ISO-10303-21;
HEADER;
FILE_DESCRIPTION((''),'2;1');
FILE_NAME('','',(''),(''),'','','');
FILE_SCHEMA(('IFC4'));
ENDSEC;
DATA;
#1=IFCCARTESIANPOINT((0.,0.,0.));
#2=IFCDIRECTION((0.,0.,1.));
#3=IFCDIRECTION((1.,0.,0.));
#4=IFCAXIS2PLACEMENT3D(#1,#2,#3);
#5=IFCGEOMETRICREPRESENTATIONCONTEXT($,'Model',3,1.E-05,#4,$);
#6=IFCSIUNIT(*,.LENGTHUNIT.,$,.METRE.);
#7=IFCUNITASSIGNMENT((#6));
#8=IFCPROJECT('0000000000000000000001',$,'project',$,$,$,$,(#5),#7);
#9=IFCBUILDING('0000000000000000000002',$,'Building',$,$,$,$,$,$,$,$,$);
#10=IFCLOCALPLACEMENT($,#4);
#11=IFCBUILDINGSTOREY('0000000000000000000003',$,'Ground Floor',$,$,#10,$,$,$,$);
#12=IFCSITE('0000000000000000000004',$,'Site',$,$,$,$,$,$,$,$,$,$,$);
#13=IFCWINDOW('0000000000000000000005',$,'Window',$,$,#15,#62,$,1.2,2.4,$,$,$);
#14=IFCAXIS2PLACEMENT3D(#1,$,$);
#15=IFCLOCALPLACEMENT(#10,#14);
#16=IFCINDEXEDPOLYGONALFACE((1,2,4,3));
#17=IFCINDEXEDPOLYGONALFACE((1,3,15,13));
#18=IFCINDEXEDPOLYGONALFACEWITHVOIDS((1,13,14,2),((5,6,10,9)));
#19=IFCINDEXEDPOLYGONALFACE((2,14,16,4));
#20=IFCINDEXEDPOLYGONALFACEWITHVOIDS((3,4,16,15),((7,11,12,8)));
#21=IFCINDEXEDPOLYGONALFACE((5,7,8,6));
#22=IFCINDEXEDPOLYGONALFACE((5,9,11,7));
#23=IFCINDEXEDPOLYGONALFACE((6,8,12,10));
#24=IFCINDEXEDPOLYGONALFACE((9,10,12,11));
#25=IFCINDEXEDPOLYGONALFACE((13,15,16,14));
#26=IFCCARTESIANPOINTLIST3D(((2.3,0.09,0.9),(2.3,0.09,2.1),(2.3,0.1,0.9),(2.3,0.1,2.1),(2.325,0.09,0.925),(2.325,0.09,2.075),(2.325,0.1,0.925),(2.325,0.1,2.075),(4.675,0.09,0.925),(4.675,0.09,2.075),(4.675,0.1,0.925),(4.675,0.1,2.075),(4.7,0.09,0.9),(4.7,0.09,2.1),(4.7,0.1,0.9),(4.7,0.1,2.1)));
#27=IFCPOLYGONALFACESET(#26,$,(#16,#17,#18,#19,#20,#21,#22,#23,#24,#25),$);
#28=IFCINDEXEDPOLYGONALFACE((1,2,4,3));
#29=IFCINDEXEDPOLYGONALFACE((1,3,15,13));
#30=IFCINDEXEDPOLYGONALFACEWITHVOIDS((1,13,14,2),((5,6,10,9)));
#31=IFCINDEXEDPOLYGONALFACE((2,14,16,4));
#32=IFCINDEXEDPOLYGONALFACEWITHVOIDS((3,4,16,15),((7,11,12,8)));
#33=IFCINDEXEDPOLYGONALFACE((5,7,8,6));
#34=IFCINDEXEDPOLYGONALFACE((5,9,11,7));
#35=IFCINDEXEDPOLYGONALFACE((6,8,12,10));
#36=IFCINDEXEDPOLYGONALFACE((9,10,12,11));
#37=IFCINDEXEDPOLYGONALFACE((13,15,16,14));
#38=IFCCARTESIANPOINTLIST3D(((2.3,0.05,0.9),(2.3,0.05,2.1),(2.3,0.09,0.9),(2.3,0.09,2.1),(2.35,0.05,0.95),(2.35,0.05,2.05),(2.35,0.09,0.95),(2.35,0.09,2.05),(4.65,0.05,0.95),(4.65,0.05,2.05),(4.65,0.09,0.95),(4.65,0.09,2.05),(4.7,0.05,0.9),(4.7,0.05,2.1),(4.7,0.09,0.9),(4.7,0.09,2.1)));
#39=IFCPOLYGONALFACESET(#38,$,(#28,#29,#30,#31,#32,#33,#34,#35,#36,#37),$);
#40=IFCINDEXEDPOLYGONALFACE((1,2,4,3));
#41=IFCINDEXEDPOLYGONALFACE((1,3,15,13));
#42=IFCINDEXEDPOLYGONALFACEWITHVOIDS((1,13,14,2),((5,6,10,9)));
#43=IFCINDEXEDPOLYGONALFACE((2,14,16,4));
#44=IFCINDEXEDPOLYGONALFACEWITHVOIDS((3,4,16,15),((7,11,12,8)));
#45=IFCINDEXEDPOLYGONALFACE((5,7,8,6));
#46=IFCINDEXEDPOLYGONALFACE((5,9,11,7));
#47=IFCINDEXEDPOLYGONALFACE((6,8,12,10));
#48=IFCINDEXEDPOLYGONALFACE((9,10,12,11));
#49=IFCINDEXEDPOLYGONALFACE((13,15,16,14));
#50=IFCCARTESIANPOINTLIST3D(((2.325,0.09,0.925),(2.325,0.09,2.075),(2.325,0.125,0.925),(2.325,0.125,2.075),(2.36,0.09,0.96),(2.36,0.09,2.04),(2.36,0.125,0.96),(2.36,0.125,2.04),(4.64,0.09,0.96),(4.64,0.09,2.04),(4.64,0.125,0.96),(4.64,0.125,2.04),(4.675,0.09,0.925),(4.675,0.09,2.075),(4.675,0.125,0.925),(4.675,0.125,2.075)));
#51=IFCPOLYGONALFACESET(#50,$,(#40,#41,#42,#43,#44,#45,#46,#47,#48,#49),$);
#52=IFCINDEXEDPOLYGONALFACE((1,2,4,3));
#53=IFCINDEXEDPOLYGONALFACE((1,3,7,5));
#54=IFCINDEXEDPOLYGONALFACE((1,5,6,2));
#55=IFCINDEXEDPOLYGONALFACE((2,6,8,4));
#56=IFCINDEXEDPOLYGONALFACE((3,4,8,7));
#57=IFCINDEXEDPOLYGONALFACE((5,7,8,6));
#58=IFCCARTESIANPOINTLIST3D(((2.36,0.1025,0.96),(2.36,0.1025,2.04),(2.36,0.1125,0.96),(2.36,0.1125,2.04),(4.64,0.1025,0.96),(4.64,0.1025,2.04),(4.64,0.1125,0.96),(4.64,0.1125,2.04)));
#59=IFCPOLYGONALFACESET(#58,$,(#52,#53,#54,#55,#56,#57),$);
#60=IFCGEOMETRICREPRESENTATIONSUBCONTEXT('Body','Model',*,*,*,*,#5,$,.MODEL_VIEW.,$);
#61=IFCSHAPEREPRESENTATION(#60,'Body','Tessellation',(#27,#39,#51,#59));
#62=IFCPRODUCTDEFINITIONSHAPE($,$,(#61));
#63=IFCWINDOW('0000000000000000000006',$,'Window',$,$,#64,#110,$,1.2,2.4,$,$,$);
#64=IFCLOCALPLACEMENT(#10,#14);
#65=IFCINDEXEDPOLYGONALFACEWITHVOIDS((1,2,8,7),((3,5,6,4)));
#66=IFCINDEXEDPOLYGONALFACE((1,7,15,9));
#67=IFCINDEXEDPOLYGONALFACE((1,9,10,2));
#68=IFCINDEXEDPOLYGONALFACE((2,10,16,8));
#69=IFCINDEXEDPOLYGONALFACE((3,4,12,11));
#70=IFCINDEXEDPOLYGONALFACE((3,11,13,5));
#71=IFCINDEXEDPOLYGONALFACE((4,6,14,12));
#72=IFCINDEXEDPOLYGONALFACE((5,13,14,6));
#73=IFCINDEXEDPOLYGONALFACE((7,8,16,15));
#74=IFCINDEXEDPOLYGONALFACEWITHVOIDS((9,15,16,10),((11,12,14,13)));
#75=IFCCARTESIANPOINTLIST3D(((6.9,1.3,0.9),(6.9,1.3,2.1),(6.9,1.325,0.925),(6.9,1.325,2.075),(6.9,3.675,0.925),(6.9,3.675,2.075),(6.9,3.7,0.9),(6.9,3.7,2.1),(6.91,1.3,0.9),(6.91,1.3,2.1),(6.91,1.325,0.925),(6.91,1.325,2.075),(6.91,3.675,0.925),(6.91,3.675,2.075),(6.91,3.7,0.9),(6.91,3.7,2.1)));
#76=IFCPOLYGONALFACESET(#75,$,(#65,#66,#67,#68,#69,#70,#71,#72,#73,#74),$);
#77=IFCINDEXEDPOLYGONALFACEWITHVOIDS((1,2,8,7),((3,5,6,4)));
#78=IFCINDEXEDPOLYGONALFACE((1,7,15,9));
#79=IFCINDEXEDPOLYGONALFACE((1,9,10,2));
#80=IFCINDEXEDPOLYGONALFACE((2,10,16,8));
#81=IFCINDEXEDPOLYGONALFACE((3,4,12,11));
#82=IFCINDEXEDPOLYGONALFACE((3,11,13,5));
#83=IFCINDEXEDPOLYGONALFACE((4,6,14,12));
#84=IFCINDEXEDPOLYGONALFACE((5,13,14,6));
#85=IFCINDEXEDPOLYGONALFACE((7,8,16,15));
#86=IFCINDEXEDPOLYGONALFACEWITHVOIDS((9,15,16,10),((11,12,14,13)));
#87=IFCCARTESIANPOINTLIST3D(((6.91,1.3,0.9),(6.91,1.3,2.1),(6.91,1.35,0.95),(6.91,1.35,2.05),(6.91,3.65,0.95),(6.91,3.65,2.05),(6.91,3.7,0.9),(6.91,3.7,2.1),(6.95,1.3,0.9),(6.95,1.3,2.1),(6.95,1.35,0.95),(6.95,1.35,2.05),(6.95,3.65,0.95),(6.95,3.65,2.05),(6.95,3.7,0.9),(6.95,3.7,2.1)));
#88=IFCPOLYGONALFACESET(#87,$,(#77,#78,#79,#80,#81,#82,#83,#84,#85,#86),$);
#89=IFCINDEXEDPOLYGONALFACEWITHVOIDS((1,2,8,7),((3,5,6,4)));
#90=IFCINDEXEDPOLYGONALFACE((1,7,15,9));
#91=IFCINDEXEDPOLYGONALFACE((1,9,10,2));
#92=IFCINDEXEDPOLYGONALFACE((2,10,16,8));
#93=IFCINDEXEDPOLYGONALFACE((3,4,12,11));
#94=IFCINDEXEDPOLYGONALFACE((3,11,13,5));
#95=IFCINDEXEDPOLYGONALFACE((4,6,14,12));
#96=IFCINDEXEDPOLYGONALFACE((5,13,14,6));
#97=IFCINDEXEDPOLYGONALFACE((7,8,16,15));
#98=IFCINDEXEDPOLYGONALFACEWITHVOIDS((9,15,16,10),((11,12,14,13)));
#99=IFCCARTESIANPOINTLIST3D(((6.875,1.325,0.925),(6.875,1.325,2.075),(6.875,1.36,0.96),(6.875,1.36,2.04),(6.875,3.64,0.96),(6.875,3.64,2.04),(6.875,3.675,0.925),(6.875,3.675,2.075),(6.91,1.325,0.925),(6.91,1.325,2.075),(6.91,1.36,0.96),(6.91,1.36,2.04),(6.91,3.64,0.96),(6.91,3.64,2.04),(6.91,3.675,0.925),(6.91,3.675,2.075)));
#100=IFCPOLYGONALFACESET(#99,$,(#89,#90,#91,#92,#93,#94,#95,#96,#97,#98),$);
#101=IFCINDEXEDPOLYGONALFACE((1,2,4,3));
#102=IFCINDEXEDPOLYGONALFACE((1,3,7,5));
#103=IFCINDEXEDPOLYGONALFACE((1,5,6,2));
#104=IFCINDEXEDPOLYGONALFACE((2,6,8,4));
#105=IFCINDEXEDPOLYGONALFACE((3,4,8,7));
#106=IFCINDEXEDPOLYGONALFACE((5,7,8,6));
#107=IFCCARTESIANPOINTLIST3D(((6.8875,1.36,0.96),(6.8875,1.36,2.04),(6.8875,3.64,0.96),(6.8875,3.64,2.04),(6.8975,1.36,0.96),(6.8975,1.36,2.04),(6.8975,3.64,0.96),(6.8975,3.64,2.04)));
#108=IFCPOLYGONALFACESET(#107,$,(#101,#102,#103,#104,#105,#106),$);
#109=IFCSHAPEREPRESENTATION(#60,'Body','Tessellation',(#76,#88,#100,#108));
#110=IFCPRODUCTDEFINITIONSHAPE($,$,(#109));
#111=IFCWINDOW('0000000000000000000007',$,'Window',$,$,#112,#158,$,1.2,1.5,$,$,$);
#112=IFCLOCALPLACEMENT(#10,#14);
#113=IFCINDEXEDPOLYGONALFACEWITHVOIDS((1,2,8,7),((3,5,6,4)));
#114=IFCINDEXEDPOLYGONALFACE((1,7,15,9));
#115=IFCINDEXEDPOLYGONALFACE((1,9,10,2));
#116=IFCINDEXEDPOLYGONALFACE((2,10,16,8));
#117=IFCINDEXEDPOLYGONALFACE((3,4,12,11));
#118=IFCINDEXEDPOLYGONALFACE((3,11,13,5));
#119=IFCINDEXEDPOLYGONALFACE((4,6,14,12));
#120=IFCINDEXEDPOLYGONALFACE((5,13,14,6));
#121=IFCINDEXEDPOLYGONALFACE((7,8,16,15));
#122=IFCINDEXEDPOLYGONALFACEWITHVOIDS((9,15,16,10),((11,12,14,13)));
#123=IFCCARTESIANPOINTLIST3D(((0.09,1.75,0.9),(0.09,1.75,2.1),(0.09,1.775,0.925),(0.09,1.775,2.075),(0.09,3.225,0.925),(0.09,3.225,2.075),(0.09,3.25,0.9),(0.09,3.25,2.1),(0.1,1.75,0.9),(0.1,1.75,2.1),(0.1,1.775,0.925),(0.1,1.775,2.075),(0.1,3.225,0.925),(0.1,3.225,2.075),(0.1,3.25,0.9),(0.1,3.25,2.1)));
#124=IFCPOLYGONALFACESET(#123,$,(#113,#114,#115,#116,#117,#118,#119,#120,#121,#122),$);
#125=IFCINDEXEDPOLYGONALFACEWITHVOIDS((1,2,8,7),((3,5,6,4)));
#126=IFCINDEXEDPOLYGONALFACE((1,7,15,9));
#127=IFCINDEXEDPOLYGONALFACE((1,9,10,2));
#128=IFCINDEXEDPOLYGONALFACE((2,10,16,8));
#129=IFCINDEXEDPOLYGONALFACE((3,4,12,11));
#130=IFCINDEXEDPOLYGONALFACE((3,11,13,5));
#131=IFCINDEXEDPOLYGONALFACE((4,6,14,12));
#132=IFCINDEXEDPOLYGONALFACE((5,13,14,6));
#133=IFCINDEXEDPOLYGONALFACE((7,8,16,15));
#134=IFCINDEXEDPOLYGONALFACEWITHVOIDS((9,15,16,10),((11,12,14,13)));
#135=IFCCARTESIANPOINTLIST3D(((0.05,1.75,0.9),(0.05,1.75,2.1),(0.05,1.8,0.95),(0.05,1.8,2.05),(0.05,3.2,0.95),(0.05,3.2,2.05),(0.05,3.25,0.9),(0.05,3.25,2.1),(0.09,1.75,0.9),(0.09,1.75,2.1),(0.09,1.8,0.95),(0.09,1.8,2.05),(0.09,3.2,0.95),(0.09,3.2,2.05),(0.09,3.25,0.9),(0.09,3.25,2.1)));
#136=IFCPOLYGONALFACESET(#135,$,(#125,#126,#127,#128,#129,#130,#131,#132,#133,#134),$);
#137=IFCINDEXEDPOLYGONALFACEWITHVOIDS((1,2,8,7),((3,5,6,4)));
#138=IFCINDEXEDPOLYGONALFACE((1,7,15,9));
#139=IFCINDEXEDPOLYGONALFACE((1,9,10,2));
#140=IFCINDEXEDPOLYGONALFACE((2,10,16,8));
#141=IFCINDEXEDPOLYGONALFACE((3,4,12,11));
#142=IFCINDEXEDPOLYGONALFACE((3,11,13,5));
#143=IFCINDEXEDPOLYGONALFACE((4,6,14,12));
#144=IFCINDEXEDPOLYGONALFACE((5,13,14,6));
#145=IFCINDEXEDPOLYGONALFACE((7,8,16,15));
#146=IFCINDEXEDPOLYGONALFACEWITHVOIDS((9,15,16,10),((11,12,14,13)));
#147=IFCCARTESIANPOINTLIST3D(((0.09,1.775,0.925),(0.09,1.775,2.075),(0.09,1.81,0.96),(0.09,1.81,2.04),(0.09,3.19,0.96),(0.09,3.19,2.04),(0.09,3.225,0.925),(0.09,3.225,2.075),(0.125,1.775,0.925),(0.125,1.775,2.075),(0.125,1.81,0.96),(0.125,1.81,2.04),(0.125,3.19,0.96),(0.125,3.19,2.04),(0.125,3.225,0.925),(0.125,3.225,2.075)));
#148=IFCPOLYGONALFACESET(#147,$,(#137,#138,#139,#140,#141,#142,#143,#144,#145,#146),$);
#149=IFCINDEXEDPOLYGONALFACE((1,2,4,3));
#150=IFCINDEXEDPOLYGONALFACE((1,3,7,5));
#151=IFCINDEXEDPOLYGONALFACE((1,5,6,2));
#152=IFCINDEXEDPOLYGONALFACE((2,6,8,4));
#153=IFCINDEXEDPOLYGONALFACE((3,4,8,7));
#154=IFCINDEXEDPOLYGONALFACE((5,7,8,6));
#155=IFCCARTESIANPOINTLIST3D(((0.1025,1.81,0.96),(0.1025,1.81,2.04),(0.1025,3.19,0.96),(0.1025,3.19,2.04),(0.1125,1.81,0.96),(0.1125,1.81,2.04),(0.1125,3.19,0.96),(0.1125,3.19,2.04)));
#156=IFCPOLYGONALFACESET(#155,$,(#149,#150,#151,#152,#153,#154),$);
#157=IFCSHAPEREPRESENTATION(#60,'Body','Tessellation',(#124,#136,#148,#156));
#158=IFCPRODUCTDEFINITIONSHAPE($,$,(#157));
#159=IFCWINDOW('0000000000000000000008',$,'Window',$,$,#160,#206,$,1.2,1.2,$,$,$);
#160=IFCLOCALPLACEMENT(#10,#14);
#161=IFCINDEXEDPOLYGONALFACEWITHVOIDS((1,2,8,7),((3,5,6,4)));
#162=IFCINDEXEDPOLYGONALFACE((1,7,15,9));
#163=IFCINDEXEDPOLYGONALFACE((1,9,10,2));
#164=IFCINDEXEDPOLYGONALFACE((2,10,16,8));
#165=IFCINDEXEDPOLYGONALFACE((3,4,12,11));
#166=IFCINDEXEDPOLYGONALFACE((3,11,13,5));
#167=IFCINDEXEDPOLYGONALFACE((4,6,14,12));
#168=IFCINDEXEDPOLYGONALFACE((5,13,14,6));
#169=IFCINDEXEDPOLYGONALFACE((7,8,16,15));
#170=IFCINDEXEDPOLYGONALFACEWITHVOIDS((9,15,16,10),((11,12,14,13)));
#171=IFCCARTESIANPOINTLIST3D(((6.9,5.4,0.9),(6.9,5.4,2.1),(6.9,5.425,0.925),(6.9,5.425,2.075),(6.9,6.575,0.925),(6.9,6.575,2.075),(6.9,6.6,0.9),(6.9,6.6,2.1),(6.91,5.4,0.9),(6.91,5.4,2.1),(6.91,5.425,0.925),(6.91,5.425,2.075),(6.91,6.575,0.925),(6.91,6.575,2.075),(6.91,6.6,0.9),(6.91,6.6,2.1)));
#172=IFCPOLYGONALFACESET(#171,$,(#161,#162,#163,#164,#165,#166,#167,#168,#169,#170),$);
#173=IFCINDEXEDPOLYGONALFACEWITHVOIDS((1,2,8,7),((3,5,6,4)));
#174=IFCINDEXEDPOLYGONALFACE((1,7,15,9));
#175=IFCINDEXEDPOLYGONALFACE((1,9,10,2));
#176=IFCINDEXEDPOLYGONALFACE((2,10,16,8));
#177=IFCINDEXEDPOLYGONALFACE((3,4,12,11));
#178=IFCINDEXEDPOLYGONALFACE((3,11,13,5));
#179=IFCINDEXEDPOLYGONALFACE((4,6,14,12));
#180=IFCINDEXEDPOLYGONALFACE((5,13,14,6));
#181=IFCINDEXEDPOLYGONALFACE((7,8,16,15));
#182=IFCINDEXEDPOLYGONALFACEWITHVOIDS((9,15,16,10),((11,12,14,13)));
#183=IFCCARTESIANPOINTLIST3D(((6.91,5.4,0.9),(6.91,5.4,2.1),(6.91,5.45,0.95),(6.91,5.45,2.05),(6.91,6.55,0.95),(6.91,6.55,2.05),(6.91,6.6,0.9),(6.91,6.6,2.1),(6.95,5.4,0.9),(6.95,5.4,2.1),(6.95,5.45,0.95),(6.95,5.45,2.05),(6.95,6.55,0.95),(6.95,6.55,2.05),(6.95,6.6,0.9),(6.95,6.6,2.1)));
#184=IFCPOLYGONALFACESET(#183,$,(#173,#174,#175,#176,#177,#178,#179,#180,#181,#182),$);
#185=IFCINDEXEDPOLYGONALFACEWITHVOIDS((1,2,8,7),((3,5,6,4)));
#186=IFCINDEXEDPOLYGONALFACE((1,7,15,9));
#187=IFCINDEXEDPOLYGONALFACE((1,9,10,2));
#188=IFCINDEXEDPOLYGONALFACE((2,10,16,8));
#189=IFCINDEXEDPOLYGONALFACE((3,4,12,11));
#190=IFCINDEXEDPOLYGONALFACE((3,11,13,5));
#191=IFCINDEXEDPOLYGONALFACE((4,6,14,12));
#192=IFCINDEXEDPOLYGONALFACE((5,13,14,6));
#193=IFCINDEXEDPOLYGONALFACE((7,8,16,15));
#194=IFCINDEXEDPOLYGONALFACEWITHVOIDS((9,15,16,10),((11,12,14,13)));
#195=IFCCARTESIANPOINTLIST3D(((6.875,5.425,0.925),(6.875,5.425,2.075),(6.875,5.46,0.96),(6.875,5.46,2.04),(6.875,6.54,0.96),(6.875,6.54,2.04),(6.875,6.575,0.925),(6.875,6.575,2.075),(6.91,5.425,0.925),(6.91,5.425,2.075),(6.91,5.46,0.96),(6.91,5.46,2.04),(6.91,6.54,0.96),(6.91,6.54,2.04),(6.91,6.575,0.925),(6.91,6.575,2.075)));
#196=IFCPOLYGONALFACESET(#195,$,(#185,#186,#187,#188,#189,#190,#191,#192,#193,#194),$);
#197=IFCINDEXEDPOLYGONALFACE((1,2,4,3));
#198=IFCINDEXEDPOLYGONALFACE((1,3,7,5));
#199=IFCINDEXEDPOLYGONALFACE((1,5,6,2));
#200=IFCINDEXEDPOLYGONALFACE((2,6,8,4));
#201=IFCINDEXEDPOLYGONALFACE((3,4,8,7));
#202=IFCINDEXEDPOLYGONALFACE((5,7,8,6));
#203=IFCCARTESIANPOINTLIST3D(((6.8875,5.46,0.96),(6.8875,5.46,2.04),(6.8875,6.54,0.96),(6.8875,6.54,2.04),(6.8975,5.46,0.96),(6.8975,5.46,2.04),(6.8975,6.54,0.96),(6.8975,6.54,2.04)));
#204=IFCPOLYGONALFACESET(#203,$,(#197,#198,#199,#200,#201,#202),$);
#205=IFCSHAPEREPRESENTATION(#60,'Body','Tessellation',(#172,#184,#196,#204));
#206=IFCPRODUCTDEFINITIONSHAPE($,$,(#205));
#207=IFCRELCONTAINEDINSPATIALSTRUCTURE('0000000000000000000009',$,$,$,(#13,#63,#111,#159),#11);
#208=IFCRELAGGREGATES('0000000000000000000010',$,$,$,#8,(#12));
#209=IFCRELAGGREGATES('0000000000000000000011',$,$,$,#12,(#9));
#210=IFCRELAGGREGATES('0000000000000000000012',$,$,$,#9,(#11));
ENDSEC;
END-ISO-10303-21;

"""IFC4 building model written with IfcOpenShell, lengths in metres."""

from ifc_helpers import new_model, si_unit, frame, origin_with_axes, place, context, subcontext, project, spatial, line, indexed_curve, outline, extrude, element, save


model = new_model("IFC4")

# Units and contexts
model_context = context("Model", 3, precision=1e-05, world=origin_with_axes())
body_context = subcontext(model_context, "Body", "Model", "MODEL_VIEW")
ifc_project = project(units=[si_unit("LENGTHUNIT", "METRE")], contexts=[model_context])

# Site, building, storey
site = spatial("IfcSite", under=ifc_project, Name="Site")
building = spatial("IfcBuilding", under=site, Name="Building")
storey_placement = place(None, origin_with_axes())
storey = spatial("IfcBuildingStorey", under=building, at=storey_placement, Name="Ground Floor")

# Windows
for number, where, z_axis, x_axis, name in (
    (1, (2.3, 0.0, 0.9), (0.0, 0.0, 1.0), (1.0, 0.0, 0.0), "Window"),
    (2, (7.0, 1.3, 0.9), (0.0, 0.0, 1.0), (0.0, 1.0, 0.0), "Window"),
):
    element("IfcWindow", number, at=place(storey_placement, frame(where, z_axis=z_axis, x_axis=x_axis)), inside=storey, Name=name, OverallHeight=1.2, OverallWidth=2.4, context=body_context, shape_type="SweptSolid", body=[
        extrude(outline(indexed_curve([(0.0, 0.0), (2.4, 0.0), (2.4, 1.2), (0.0, 1.2)], segments=[line(1, 2, 3, 4, 1)]), holes=[indexed_curve([(0.025, 0.025), (2.375, 0.025), (2.375, 1.175), (0.025, 1.175)], segments=[line(1, 2, 3, 4, 1)])]), frame((0.0, 0.09, 0.0), z_axis=(0.0, -1.0, 0.0), x_axis=(1.0, 0.0, 0.0)), (0.0, 0.0, -1.0), 0.01),
        extrude(outline(indexed_curve([(0.0, 0.0), (2.4, 0.0), (2.4, 1.2), (0.0, 1.2)], segments=[line(1, 2, 3, 4, 1)]), holes=[indexed_curve([(0.05, 0.05), (2.35, 0.05), (2.35, 1.15), (0.05, 1.15)], segments=[line(1, 2, 3, 4, 1)])]), frame((0.0, 0.05, 0.0), z_axis=(0.0, -1.0, 0.0), x_axis=(1.0, 0.0, 0.0)), (0.0, 0.0, -1.0), 0.04),
        extrude(outline(indexed_curve([(0.0, 0.0), (2.35, 0.0), (2.35, 1.15), (0.0, 1.15)], segments=[line(1, 2, 3, 4, 1)]), holes=[indexed_curve([(0.035, 0.035), (2.315, 0.035), (2.315, 1.115), (0.035, 1.115)], segments=[line(1, 2, 3, 4, 1)])]), frame((0.025, 0.09, 0.025), z_axis=(0.0, -1.0, 0.0), x_axis=(1.0, 0.0, 0.0)), (0.0, 0.0, -1.0), 0.035),
        extrude(outline(indexed_curve([(0.035, 0.035), (2.315, 0.035), (2.315, 1.115), (0.035, 1.115)], segments=[line(1, 2, 3, 4, 1)])), frame((0.025, 0.1025, 0.025), z_axis=(0.0, -1.0, 0.0), x_axis=(1.0, 0.0, 0.0)), (0.0, 0.0, -1.0), 0.01),
    ])
window_1_placement = place(storey_placement, frame((0.0, 3.25, 0.9), z_axis=(0.0, 0.0, 1.0), x_axis=(0.0, -1.0, 0.0)))
element("IfcWindow", 3, at=window_1_placement, inside=storey, Name="Window", OverallHeight=1.2, OverallWidth=1.5, context=body_context, shape_type="SweptSolid", body=[
    extrude(outline(indexed_curve([(0.0, 0.0), (1.5, 0.0), (1.5, 1.2), (0.0, 1.2)], segments=[line(1, 2, 3, 4, 1)]), holes=[indexed_curve([(0.025, 0.025), (1.475, 0.025), (1.475, 1.175), (0.025, 1.175)], segments=[line(1, 2, 3, 4, 1)])]), frame((0.0, 0.09, 0.0), z_axis=(0.0, -1.0, 0.0), x_axis=(1.0, 0.0, 0.0)), (0.0, 0.0, -1.0), 0.01),
    extrude(outline(indexed_curve([(0.0, 0.0), (1.5, 0.0), (1.5, 1.2), (0.0, 1.2)], segments=[line(1, 2, 3, 4, 1)]), holes=[indexed_curve([(0.05, 0.05), (1.45, 0.05), (1.45, 1.15), (0.05, 1.15)], segments=[line(1, 2, 3, 4, 1)])]), frame((0.0, 0.05, 0.0), z_axis=(0.0, -1.0, 0.0), x_axis=(1.0, 0.0, 0.0)), (0.0, 0.0, -1.0), 0.04),
    extrude(outline(indexed_curve([(0.0, 0.0), (1.45, 0.0), (1.45, 1.15), (0.0, 1.15)], segments=[line(1, 2, 3, 4, 1)]), holes=[indexed_curve([(0.035, 0.035), (1.415, 0.035), (1.415, 1.115), (0.035, 1.115)], segments=[line(1, 2, 3, 4, 1)])]), frame((0.025, 0.09, 0.025), z_axis=(0.0, -1.0, 0.0), x_axis=(1.0, 0.0, 0.0)), (0.0, 0.0, -1.0), 0.035),
    extrude(outline(indexed_curve([(0.035, 0.035), (1.415, 0.035), (1.415, 1.115), (0.035, 1.115)], segments=[line(1, 2, 3, 4, 1)])), frame((0.025, 0.1025, 0.025), z_axis=(0.0, -1.0, 0.0), x_axis=(1.0, 0.0, 0.0)), (0.0, 0.0, -1.0), 0.01),
])
window_2_placement = place(storey_placement, frame((7.0, 5.4, 0.9), z_axis=(0.0, 0.0, 1.0), x_axis=(0.0, 1.0, 0.0)))
element("IfcWindow", 4, at=window_2_placement, inside=storey, Name="Window", OverallHeight=1.2, OverallWidth=1.2, context=body_context, shape_type="SweptSolid", body=[
    extrude(outline(indexed_curve([(0.0, 0.0), (1.2, 0.0), (1.2, 1.2), (0.0, 1.2)], segments=[line(1, 2, 3, 4, 1)]), holes=[indexed_curve([(0.025, 0.025), (1.175, 0.025), (1.175, 1.175), (0.025, 1.175)], segments=[line(1, 2, 3, 4, 1)])]), frame((0.0, 0.09, 0.0), z_axis=(0.0, -1.0, 0.0), x_axis=(1.0, 0.0, 0.0)), (0.0, 0.0, -1.0), 0.01),
    extrude(outline(indexed_curve([(0.0, 0.0), (1.2, 0.0), (1.2, 1.2), (0.0, 1.2)], segments=[line(1, 2, 3, 4, 1)]), holes=[indexed_curve([(0.05, 0.05), (1.15, 0.05), (1.15, 1.15), (0.05, 1.15)], segments=[line(1, 2, 3, 4, 1)])]), frame((0.0, 0.05, 0.0), z_axis=(0.0, -1.0, 0.0), x_axis=(1.0, 0.0, 0.0)), (0.0, 0.0, -1.0), 0.04),
    extrude(outline(indexed_curve([(0.0, 0.0), (1.15, 0.0), (1.15, 1.15), (0.0, 1.15)], segments=[line(1, 2, 3, 4, 1)]), holes=[indexed_curve([(0.035, 0.035), (1.115, 0.035), (1.115, 1.115), (0.035, 1.115)], segments=[line(1, 2, 3, 4, 1)])]), frame((0.025, 0.09, 0.025), z_axis=(0.0, -1.0, 0.0), x_axis=(1.0, 0.0, 0.0)), (0.0, 0.0, -1.0), 0.035),
    extrude(outline(indexed_curve([(0.035, 0.035), (1.115, 0.035), (1.115, 1.115), (0.035, 1.115)], segments=[line(1, 2, 3, 4, 1)])), frame((0.025, 0.1025, 0.025), z_axis=(0.0, -1.0, 0.0), x_axis=(1.0, 0.0, 0.0)), (0.0, 0.0, -1.0), 0.01),
])

save(model, "model.ifc")
